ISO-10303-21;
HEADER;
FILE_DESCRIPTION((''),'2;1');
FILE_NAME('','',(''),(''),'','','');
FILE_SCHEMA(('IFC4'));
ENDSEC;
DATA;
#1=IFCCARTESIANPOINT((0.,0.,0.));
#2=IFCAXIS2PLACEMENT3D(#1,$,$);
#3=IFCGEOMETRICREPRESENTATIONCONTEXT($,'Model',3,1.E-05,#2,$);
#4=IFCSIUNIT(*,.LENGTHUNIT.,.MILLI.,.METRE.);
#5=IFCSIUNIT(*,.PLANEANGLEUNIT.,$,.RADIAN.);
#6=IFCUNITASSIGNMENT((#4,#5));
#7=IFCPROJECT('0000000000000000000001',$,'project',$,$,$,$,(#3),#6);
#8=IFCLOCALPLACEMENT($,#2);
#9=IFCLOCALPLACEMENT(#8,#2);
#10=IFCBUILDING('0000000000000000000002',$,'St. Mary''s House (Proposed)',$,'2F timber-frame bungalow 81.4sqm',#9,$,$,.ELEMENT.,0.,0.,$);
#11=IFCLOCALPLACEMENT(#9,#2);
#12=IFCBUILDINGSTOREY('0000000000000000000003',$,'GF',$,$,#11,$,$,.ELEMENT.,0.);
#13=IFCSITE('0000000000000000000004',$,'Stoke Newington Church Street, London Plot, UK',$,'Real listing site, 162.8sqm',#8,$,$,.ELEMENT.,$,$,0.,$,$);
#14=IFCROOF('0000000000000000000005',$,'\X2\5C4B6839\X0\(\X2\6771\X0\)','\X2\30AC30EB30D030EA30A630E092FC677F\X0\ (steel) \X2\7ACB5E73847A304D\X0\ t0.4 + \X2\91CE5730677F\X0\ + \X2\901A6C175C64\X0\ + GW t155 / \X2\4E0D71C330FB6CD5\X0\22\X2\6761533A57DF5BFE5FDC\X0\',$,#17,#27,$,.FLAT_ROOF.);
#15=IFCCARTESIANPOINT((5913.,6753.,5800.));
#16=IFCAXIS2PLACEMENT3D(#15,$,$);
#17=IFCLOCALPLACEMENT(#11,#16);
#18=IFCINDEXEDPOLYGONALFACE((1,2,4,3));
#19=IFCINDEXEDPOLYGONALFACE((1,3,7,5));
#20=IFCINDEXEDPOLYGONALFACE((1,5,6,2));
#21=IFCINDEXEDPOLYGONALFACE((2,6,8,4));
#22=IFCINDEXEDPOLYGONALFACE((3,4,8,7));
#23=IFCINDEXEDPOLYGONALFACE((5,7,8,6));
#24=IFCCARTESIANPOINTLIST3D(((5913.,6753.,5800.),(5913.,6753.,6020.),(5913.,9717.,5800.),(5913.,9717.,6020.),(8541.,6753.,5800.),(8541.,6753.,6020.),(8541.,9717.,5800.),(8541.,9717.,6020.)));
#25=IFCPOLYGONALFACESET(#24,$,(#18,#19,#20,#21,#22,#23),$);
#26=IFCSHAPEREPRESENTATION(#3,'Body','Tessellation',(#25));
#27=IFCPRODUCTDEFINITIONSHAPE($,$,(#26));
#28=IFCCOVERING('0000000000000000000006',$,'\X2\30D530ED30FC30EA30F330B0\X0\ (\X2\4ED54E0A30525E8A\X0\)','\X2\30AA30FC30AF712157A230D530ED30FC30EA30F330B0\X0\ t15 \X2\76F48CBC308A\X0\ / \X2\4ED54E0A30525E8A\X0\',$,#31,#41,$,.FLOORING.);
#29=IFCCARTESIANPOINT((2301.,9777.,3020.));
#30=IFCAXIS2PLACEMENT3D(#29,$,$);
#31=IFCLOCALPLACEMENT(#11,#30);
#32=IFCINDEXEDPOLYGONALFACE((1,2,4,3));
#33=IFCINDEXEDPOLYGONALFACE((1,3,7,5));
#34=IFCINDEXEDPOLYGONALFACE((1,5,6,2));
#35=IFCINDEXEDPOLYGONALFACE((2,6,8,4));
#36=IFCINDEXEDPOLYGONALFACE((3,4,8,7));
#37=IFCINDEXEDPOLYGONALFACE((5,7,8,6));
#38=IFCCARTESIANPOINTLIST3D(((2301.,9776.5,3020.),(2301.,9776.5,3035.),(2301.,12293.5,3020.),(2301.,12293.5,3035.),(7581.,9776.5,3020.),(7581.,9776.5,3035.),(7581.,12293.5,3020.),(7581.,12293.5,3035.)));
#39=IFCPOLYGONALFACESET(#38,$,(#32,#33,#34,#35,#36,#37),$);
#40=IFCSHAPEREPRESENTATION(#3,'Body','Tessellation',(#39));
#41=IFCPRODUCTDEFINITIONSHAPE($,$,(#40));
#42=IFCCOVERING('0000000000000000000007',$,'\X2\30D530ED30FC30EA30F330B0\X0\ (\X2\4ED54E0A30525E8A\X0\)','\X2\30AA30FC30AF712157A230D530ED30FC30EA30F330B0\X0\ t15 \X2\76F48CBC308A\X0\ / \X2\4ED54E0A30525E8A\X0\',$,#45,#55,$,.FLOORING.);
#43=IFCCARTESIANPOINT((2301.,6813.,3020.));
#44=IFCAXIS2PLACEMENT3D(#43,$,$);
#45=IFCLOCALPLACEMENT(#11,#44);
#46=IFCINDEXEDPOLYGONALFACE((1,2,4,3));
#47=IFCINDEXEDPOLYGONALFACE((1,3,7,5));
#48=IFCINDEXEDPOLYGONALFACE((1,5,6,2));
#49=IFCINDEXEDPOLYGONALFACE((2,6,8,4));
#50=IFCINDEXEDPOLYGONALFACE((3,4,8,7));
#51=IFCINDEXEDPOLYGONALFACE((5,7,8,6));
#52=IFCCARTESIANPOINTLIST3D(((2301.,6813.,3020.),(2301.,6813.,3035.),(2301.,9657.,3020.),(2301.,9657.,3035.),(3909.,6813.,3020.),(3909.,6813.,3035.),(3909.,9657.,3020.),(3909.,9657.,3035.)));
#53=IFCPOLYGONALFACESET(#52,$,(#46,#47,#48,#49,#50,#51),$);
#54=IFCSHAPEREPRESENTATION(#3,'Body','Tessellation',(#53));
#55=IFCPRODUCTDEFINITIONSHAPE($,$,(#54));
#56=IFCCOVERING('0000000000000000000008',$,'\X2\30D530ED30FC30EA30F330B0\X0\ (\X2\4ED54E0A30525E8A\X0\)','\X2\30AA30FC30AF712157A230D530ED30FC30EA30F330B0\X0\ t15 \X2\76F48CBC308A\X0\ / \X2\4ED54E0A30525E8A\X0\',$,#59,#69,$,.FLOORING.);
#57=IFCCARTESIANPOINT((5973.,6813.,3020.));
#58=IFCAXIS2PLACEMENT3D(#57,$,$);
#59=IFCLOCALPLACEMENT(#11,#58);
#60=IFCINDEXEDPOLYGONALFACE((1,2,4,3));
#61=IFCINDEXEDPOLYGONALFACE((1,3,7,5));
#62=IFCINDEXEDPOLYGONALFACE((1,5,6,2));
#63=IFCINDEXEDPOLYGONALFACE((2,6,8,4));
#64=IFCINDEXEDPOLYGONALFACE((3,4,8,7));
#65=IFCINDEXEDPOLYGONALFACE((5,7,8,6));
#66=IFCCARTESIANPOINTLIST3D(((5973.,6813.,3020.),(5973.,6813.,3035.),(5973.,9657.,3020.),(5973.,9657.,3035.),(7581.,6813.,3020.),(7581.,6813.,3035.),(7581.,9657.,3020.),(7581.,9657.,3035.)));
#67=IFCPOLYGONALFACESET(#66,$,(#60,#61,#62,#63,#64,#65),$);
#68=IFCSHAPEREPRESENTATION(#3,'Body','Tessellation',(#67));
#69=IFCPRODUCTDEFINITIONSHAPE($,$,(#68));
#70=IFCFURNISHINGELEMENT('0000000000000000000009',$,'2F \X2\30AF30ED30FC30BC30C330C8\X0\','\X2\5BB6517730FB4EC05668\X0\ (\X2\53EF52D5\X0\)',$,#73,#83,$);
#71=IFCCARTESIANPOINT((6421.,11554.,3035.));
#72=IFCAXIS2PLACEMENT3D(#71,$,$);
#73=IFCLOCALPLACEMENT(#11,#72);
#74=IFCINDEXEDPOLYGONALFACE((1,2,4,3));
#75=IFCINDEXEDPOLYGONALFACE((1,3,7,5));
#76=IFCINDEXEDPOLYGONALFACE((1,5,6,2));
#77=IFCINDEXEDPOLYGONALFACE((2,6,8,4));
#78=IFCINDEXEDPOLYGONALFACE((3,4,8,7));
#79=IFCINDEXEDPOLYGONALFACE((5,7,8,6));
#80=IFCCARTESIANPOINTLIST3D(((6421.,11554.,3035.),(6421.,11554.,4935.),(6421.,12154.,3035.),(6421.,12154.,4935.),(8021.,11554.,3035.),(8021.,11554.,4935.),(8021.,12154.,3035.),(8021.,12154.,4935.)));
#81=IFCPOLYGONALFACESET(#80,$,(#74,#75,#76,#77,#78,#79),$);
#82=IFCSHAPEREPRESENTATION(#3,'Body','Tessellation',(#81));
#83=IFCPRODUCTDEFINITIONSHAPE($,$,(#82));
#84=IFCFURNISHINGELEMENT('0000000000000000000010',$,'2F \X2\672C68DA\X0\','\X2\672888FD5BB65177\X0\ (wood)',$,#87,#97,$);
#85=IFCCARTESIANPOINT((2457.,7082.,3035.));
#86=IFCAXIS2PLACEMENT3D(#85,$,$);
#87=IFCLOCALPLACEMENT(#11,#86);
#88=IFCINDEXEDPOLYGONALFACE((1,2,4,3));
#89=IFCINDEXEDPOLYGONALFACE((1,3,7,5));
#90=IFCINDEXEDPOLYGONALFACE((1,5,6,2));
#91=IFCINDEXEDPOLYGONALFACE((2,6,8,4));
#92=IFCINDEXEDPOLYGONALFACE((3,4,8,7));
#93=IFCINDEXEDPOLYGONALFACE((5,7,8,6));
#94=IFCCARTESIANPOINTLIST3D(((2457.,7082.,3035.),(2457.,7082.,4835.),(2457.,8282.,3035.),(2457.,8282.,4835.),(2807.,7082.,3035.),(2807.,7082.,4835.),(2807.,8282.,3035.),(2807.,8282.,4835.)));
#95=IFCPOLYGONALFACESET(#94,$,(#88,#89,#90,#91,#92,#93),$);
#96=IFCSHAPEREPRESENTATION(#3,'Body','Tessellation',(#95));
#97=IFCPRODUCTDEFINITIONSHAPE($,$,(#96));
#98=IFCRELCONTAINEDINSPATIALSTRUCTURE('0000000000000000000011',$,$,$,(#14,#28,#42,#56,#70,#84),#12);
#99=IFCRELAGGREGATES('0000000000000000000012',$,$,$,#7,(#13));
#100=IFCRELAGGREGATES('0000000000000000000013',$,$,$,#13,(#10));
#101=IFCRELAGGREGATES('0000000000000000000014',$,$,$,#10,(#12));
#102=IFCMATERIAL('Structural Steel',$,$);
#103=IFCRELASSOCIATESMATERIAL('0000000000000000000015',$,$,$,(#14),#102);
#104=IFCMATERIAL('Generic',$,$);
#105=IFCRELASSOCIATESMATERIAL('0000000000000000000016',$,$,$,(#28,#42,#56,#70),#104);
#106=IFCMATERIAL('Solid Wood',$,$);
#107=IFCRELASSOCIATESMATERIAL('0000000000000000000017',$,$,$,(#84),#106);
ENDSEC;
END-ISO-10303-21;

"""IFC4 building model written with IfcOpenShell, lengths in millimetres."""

from ifc_helpers import new_model, si_unit, frame, frame_2d, origin, place, context, project, spatial, rectangle, extrude, material, element, save


model = new_model("IFC4")

# Units and contexts
model_context = context("Model", 3, precision=1e-05, world=origin())
ifc_project = project(units=[si_unit("LENGTHUNIT", "METRE", prefix="MILLI"), si_unit("PLANEANGLEUNIT", "RADIAN")], contexts=[model_context])

# Site, building, storey
site_placement = place(None, origin())
site = spatial("IfcSite", under=ifc_project, at=site_placement, Name="Stoke Newington Church Street, London Plot, UK", ObjectType="Real listing site, 162.8sqm", CompositionType="ELEMENT", RefElevation=0.0)
building_placement = place(site_placement, origin())
building = spatial("IfcBuilding", under=site, at=building_placement, Name="St. Mary's House (Proposed)", ObjectType="2F timber-frame bungalow 81.4sqm", CompositionType="ELEMENT", ElevationOfRefHeight=0.0, ElevationOfTerrain=0.0)
storey_placement = place(building_placement, origin())
storey = spatial("IfcBuildingStorey", under=building, at=storey_placement, Name="GF", CompositionType="ELEMENT", Elevation=0.0)

# Shared definitions
ifc_material_1 = material(Name="Solid Wood")

# Roof
ifc_material_2 = material(Name="Structural Steel")
roof_1_placement = place(storey_placement, frame((5913.0, 6753.0, 5800.0)))
element("IfcRoof", 1, at=roof_1_placement, inside=storey, material=ifc_material_2, Name="屋根(東)", Description="ガルバリウム鋼板 (steel) 立平葺き t0.4 + 野地板 + 通気層 + GW t155 / 不燃・法22条区域対応", PredefinedType="FLAT_ROOF", context=model_context, shape_type="SweptSolid", body=[
    extrude(rectangle(XDim=2628.0, YDim=2964.0, at=frame_2d((1314.0, 1482.0))), frame((5913.0, 6753.0, 5800.0)), (0.0, 0.0, 1.0), 220.0),
])

# Coverings
ifc_material_3 = material(Name="Generic")
covering_1_placement = place(storey_placement, frame((2301.0, 9777.0, 3020.0)))
element("IfcCovering", 2, at=covering_1_placement, inside=storey, material=ifc_material_3, Name="フローリング (仕上げ床)", Description="オーク無垢フローリング t15 直貼り / 仕上げ床", PredefinedType="FLOORING", context=model_context, shape_type="SweptSolid", body=[
    extrude(rectangle(XDim=5280.0, YDim=2517.0, at=frame_2d((2640.0, 1258.0))), frame((2301.0, 9777.0, 3020.0)), (0.0, 0.0, 1.0), 15.0),
])
covering_2_placement = place(storey_placement, frame((2301.0, 6813.0, 3020.0)))
element("IfcCovering", 3, at=covering_2_placement, inside=storey, material=ifc_material_3, Name="フローリング (仕上げ床)", Description="オーク無垢フローリング t15 直貼り / 仕上げ床", PredefinedType="FLOORING", context=model_context, shape_type="SweptSolid", body=[
    extrude(rectangle(XDim=1608.0, YDim=2844.0, at=frame_2d((804.0, 1422.0))), frame((2301.0, 6813.0, 3020.0)), (0.0, 0.0, 1.0), 15.0),
])
covering_3_placement = place(storey_placement, frame((5973.0, 6813.0, 3020.0)))
element("IfcCovering", 4, at=covering_3_placement, inside=storey, material=ifc_material_3, Name="フローリング (仕上げ床)", Description="オーク無垢フローリング t15 直貼り / 仕上げ床", PredefinedType="FLOORING", context=model_context, shape_type="SweptSolid", body=[
    extrude(rectangle(XDim=1608.0, YDim=2844.0, at=frame_2d((804.0, 1422.0))), frame((5973.0, 6813.0, 3020.0)), (0.0, 0.0, 1.0), 15.0),
])

# Furnishing elements
furnishing_1_placement = place(storey_placement, frame((6421.0, 11554.0, 3035.0)))
element("IfcFurnishingElement", 5, at=furnishing_1_placement, inside=storey, material=ifc_material_3, Name="2F クローゼット", Description="家具・什器 (可動)", context=model_context, shape_type="SweptSolid", body=[
    extrude(rectangle(XDim=1600.0, YDim=600.0, at=frame_2d((800.0, 300.0))), frame((6421.0, 11554.0, 3035.0)), (0.0, 0.0, 1.0), 1900.0),
])
furnishing_2_placement = place(storey_placement, frame((2457.0, 7082.0, 3035.0)))
element("IfcFurnishingElement", 6, at=furnishing_2_placement, inside=storey, material=ifc_material_1, Name="2F 本棚", Description="木製家具 (wood)", context=model_context, shape_type="SweptSolid", body=[
    extrude(rectangle(XDim=350.0, YDim=1200.0, at=frame_2d((175.0, 600.0))), frame((2457.0, 7082.0, 3035.0)), (0.0, 0.0, 1.0), 1800.0),
])

save(model, "model.ifc")
